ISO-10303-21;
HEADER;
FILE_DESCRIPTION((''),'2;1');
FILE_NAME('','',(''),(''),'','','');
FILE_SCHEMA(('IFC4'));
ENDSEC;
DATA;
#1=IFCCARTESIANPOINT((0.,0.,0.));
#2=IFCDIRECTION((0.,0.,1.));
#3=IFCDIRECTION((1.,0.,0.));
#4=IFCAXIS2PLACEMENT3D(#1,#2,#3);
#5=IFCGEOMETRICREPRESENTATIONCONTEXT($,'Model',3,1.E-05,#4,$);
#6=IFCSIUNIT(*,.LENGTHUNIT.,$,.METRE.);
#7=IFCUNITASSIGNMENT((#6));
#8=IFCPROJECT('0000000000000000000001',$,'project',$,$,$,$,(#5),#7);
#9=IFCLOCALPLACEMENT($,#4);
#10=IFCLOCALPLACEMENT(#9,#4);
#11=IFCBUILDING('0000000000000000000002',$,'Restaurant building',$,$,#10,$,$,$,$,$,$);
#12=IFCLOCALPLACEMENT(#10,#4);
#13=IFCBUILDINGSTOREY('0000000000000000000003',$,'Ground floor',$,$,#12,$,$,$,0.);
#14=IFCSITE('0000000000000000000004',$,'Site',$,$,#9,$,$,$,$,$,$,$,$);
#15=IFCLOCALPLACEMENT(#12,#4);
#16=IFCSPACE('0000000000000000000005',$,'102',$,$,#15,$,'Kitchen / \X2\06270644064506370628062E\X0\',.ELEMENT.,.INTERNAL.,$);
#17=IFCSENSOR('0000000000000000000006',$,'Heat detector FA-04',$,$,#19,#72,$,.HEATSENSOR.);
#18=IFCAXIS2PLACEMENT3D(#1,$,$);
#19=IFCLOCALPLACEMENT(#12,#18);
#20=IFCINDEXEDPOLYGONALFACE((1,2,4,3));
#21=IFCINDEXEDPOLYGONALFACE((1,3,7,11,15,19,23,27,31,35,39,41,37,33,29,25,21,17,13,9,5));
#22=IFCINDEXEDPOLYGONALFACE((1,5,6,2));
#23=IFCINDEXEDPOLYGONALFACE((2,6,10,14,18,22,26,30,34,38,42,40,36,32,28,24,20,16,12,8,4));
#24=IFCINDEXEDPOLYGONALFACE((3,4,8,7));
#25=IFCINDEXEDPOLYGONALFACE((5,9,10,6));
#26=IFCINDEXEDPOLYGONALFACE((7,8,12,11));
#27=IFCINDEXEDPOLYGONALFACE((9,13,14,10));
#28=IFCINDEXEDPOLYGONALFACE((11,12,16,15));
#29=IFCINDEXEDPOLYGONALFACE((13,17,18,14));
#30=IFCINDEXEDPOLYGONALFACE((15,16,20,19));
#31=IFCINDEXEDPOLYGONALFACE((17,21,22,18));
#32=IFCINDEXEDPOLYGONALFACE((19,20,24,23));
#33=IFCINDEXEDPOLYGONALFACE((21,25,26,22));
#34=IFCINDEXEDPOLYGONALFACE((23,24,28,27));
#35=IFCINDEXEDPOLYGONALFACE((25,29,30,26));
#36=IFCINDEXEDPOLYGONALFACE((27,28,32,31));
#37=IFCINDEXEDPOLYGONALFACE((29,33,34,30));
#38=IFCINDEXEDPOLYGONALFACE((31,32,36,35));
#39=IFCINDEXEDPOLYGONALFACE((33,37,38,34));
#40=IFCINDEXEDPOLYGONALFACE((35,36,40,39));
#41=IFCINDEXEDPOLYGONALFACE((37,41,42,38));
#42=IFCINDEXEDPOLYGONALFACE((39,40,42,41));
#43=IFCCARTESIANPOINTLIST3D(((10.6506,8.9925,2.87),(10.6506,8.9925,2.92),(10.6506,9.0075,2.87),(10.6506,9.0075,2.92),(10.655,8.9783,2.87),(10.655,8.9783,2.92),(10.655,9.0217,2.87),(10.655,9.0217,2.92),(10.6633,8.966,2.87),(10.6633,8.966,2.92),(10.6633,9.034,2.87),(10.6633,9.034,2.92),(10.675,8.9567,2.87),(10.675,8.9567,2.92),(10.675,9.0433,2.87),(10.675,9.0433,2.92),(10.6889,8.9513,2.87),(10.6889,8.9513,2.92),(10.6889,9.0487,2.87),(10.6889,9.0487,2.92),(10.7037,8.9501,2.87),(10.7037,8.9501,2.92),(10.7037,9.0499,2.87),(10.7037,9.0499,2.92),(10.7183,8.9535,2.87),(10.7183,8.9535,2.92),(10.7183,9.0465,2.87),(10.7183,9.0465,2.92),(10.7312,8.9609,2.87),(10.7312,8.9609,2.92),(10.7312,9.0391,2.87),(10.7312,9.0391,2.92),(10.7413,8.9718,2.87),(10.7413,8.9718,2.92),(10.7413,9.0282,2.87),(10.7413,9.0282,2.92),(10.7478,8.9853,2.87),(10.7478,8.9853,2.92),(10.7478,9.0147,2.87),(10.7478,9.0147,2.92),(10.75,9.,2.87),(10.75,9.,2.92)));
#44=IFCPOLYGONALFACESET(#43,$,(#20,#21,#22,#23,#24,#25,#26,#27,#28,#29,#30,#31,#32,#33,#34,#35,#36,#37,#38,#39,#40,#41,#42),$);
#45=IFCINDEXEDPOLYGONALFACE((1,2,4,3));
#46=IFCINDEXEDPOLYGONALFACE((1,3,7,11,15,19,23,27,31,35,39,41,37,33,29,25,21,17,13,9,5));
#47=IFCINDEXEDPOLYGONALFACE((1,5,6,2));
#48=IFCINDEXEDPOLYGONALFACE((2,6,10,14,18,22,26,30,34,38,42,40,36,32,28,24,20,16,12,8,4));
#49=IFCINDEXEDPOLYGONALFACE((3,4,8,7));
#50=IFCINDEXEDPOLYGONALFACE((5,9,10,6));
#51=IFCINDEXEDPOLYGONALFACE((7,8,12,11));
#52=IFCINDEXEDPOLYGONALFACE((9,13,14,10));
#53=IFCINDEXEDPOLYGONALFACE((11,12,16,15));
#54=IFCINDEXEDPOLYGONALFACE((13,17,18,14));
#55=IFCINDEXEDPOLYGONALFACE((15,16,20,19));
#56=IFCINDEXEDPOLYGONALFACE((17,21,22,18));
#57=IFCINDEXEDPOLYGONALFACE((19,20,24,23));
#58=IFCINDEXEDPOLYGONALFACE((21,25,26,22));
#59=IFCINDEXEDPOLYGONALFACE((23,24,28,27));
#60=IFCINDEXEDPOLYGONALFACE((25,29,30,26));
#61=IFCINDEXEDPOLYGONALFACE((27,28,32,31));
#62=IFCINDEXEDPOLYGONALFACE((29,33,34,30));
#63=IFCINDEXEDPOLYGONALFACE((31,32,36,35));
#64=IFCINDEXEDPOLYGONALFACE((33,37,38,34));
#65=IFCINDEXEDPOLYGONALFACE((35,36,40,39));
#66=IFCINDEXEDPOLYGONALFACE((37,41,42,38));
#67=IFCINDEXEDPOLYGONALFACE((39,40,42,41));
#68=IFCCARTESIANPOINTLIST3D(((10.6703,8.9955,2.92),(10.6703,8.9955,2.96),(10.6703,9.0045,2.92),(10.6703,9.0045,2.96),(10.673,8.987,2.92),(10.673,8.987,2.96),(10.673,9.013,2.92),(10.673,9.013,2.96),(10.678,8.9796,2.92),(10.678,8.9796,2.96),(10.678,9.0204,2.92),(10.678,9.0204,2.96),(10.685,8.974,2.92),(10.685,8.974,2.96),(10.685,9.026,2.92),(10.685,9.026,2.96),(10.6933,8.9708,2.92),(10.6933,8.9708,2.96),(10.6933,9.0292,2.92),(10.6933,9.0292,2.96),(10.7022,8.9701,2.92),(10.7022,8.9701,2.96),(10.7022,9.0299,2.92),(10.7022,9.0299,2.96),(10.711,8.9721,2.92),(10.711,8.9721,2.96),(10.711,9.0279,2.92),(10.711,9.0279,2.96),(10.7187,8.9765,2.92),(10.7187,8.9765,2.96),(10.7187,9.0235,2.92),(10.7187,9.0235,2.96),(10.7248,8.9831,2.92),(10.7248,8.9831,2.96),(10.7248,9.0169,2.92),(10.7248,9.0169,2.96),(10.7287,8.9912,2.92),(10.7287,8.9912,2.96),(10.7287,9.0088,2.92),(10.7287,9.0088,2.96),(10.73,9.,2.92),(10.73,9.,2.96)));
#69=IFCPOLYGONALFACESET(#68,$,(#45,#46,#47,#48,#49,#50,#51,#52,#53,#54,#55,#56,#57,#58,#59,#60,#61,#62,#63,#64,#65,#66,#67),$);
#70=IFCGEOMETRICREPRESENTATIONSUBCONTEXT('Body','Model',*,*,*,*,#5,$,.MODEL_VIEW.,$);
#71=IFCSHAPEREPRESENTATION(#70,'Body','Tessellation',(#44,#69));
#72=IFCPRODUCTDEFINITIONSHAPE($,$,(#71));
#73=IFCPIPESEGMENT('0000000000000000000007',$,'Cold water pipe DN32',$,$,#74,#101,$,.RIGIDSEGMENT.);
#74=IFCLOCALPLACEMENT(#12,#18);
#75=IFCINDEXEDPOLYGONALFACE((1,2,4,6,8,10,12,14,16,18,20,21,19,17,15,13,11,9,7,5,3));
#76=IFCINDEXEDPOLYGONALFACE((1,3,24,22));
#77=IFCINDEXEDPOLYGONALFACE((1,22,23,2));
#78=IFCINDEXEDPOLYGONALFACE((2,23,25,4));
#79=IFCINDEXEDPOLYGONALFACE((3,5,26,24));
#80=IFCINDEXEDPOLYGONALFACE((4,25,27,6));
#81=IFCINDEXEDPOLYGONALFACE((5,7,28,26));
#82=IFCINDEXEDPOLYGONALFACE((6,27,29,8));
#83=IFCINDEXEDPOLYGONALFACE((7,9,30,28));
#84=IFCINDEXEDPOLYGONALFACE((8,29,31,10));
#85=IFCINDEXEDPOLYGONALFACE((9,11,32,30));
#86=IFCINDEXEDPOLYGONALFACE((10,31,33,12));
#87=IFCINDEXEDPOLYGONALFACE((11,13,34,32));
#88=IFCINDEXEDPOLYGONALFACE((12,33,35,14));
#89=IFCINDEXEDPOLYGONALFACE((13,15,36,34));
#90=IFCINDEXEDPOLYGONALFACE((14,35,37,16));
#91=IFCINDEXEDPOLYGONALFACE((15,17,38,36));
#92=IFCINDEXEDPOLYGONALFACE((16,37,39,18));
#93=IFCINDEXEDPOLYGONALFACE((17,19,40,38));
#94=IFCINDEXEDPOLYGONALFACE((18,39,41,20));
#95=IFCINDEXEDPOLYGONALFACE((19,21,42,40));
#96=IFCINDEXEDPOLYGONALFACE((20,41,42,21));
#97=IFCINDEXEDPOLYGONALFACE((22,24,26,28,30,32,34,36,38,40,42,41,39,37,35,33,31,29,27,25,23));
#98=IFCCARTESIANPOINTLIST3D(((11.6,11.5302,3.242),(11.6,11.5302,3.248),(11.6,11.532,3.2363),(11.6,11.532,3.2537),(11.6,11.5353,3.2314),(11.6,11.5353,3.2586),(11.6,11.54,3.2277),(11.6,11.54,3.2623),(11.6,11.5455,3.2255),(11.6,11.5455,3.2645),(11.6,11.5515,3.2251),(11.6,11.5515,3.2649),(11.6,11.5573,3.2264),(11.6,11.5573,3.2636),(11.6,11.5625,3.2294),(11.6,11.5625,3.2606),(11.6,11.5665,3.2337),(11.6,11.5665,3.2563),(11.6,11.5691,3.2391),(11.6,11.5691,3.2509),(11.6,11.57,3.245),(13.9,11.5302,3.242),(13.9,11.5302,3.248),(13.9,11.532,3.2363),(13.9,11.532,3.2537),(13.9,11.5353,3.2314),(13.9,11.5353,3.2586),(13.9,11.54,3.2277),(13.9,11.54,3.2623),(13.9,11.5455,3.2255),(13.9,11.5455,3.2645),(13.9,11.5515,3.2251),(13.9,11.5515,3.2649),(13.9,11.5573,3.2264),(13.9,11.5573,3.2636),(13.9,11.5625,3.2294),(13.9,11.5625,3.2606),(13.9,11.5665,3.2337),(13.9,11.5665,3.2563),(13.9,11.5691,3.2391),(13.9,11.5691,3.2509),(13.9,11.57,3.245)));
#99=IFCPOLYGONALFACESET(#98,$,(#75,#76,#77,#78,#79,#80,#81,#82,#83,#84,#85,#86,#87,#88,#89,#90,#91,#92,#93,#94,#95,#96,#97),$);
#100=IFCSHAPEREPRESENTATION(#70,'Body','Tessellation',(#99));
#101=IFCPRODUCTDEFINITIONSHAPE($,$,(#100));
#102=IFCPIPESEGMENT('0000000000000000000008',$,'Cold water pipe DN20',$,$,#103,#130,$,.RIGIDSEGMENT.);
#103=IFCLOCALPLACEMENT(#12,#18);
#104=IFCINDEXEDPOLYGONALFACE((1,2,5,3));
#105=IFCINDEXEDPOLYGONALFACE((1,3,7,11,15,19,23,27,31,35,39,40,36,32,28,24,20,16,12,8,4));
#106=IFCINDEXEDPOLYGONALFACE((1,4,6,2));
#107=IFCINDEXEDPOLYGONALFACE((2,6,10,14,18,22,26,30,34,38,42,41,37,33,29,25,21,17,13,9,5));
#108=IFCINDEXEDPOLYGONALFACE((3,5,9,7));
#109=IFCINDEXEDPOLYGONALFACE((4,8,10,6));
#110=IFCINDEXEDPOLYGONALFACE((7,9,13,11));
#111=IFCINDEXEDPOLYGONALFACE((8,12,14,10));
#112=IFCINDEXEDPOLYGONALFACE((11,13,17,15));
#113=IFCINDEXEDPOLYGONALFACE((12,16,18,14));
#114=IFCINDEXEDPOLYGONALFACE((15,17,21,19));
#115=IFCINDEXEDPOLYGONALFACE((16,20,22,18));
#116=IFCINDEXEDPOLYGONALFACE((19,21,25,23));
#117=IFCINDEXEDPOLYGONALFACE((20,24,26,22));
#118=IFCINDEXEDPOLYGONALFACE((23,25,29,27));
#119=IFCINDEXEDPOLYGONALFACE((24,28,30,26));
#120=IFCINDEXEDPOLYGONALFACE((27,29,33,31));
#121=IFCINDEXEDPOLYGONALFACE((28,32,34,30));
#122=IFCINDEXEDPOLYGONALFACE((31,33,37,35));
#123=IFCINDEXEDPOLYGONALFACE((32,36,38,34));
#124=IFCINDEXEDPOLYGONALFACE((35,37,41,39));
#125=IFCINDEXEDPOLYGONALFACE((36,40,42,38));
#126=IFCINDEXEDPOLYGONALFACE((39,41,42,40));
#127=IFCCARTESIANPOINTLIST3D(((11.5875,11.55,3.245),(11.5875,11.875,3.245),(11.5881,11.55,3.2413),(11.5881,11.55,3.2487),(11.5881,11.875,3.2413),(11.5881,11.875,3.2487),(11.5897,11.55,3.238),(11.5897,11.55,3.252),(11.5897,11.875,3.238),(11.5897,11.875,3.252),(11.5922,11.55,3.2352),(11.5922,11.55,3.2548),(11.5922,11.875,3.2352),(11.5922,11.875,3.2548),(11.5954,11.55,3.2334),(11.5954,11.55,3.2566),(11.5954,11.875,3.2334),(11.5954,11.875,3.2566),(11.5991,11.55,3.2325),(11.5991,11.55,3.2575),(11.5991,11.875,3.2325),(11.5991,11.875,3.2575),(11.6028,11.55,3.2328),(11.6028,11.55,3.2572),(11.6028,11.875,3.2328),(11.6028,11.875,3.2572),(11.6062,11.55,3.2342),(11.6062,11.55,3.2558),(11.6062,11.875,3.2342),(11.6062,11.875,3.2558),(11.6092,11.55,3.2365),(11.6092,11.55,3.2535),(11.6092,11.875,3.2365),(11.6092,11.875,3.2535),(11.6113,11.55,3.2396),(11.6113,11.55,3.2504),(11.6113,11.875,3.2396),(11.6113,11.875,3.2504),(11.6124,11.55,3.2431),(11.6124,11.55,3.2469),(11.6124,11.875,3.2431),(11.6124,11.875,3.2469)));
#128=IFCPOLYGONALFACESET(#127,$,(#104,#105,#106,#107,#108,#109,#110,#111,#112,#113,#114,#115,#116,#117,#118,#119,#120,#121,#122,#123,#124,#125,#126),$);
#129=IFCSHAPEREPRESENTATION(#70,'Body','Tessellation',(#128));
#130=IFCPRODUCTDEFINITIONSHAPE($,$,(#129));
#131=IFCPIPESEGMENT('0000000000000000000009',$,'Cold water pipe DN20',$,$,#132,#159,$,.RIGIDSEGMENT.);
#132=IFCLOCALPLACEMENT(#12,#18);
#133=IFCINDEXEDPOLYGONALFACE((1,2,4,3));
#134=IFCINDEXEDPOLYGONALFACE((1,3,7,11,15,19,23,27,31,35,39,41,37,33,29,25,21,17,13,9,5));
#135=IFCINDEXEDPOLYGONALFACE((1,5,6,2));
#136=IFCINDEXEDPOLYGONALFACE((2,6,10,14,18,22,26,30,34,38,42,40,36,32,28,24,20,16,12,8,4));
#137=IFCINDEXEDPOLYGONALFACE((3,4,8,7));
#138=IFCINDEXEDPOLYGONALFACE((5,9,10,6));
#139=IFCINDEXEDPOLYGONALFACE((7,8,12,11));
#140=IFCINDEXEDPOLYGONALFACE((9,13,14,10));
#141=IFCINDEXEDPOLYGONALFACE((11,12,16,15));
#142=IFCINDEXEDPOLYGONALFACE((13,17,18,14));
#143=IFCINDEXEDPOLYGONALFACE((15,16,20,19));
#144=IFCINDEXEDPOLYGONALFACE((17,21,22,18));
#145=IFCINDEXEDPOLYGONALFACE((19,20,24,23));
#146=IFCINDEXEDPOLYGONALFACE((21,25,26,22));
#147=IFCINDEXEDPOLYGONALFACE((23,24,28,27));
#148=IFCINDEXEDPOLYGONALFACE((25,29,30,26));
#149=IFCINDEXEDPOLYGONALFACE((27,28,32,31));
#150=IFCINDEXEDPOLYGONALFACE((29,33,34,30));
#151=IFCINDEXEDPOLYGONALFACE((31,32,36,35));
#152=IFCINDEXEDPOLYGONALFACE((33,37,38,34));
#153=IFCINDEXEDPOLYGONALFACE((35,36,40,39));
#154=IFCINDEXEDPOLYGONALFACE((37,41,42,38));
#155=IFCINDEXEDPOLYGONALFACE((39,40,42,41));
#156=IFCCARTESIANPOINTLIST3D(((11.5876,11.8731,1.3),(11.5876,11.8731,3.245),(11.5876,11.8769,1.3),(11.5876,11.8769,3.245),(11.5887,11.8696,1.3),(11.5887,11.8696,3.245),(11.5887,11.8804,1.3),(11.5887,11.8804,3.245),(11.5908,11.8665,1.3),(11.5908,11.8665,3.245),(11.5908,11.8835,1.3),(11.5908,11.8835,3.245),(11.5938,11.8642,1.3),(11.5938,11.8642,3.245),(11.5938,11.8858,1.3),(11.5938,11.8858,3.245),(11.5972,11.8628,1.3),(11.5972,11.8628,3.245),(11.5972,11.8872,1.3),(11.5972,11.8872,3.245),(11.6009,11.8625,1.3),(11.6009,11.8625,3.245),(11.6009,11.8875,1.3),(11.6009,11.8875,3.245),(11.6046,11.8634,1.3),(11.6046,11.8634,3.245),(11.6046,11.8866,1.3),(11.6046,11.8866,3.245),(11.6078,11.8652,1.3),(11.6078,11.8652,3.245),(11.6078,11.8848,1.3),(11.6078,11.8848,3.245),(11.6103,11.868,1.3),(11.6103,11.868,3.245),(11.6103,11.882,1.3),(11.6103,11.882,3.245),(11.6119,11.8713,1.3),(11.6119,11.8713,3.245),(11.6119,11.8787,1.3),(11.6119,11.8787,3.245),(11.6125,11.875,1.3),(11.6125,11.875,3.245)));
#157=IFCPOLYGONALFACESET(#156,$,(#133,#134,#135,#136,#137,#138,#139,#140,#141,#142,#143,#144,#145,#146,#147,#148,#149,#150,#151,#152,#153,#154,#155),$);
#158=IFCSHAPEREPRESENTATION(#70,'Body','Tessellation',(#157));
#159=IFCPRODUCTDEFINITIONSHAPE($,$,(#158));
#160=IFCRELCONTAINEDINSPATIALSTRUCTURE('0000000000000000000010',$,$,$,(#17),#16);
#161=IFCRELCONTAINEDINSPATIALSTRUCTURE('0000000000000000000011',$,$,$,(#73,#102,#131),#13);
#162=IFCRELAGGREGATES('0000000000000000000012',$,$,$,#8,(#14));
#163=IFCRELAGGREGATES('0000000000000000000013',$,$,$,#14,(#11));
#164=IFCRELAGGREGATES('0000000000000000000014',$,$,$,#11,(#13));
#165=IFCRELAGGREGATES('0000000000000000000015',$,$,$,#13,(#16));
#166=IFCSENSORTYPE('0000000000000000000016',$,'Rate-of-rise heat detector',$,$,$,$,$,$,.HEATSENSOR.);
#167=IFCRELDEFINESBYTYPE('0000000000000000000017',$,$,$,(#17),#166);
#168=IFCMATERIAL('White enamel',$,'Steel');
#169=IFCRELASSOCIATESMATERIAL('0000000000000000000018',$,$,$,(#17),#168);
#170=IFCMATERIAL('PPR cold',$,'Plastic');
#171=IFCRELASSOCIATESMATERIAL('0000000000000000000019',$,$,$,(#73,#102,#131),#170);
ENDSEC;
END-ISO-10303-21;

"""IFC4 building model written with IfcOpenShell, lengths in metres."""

from ifc_helpers import new_model, si_unit, frame, origin, origin_with_axes, origin_2d, place, context, subcontext, project, spatial, circle, extrude, source, transform, mapped, material, type_object, type_shapes, element, save


model = new_model("IFC4")

# Units and contexts
model_context = context("Model", 3, precision=1e-05, world=origin_with_axes())
body_context = subcontext(model_context, "Body", "Model", "MODEL_VIEW")
ifc_project = project(units=[si_unit("LENGTHUNIT", "METRE")], contexts=[model_context])

# Site, building, storey, space
site_placement = place(None, origin_with_axes())
site = spatial("IfcSite", under=ifc_project, at=site_placement, Name="Site")
building_placement = place(site_placement, origin_with_axes())
building = spatial("IfcBuilding", under=site, at=building_placement, Name="Restaurant building")
storey_placement = place(building_placement, origin_with_axes())
storey = spatial("IfcBuildingStorey", under=building, at=storey_placement, Name="Ground floor", Elevation=0.0)
space_placement = place(storey_placement, origin_with_axes())
space = spatial("IfcSpace", under=storey, at=space_placement, Name="102", LongName="Kitchen / المطبخ", CompositionType="ELEMENT", PredefinedType="INTERNAL")

# Sensor
ifc_material_1 = material(Name="White enamel", Category="Steel")
sensor_type = type_object("IfcSensorType", Name="Rate-of-rise heat detector", PredefinedType="HEATSENSOR")
shared_shape = source(origin(), body_context, "Body", "SweptSolid", [
    extrude(circle(Radius=0.05, at=origin_2d()), frame((0.0, 0.0, -0.09)), (0.0, 0.0, 1.0), 0.05),
    extrude(circle(Radius=0.03, at=origin_2d()), frame((0.0, 0.0, -0.04)), (0.0, 0.0, 1.0), 0.04),
])
type_shapes(sensor_type, [shared_shape])
sensor_placement = place(storey_placement, frame((10.7, 9.0, 2.96)))
element("IfcSensor", 1, at=sensor_placement, inside=space, type_object=sensor_type, material=ifc_material_1, Name="Heat detector FA-04", PredefinedType="HEATSENSOR", context=body_context, shape_type="MappedRepresentation", body=[
    mapped(shared_shape, transform((0.0, 0.0, 0.0))),
])

# Pipe segments
ifc_material_2 = material(Name="PPR cold", Category="Plastic")
pipe_segment_1_placement = place(storey_placement, frame((11.6, 11.55, 3.245)))
element("IfcPipeSegment", 2, at=pipe_segment_1_placement, inside=storey, material=ifc_material_2, Name="Cold water pipe DN32", PredefinedType="RIGIDSEGMENT", context=body_context, shape_type="SweptSolid", body=[
    extrude(circle(Radius=0.02, at=origin_2d()), frame((0.0, 0.0, 0.0), z_axis=(1.0, 0.0, 0.0), x_axis=(0.0, 1.0, 0.0)), (0.0, 0.0, 1.0), 2.3),
])
pipe_segment_2_placement = place(storey_placement, frame((11.6, 11.55, 3.245)))
element("IfcPipeSegment", 3, at=pipe_segment_2_placement, inside=storey, material=ifc_material_2, Name="Cold water pipe DN20", PredefinedType="RIGIDSEGMENT", context=body_context, shape_type="SweptSolid", body=[
    extrude(circle(Radius=0.0125, at=origin_2d()), frame((0.0, 0.0, 0.0), z_axis=(0.0, 1.0, 0.0), x_axis=(-1.0, 0.0, 0.0)), (0.0, 0.0, 1.0), 0.325),
])
pipe_segment_3_placement = place(storey_placement, frame((11.6, 11.875, 3.245)))
element("IfcPipeSegment", 4, at=pipe_segment_3_placement, inside=storey, material=ifc_material_2, Name="Cold water pipe DN20", PredefinedType="RIGIDSEGMENT", context=body_context, shape_type="SweptSolid", body=[
    extrude(circle(Radius=0.0125, at=origin_2d()), frame((0.0, 0.0, 0.0), z_axis=(0.0, 0.0, -1.0), x_axis=(1.0, 0.0, 0.0)), (0.0, 0.0, 1.0), 1.945),
])

save(model, "model.ifc")
